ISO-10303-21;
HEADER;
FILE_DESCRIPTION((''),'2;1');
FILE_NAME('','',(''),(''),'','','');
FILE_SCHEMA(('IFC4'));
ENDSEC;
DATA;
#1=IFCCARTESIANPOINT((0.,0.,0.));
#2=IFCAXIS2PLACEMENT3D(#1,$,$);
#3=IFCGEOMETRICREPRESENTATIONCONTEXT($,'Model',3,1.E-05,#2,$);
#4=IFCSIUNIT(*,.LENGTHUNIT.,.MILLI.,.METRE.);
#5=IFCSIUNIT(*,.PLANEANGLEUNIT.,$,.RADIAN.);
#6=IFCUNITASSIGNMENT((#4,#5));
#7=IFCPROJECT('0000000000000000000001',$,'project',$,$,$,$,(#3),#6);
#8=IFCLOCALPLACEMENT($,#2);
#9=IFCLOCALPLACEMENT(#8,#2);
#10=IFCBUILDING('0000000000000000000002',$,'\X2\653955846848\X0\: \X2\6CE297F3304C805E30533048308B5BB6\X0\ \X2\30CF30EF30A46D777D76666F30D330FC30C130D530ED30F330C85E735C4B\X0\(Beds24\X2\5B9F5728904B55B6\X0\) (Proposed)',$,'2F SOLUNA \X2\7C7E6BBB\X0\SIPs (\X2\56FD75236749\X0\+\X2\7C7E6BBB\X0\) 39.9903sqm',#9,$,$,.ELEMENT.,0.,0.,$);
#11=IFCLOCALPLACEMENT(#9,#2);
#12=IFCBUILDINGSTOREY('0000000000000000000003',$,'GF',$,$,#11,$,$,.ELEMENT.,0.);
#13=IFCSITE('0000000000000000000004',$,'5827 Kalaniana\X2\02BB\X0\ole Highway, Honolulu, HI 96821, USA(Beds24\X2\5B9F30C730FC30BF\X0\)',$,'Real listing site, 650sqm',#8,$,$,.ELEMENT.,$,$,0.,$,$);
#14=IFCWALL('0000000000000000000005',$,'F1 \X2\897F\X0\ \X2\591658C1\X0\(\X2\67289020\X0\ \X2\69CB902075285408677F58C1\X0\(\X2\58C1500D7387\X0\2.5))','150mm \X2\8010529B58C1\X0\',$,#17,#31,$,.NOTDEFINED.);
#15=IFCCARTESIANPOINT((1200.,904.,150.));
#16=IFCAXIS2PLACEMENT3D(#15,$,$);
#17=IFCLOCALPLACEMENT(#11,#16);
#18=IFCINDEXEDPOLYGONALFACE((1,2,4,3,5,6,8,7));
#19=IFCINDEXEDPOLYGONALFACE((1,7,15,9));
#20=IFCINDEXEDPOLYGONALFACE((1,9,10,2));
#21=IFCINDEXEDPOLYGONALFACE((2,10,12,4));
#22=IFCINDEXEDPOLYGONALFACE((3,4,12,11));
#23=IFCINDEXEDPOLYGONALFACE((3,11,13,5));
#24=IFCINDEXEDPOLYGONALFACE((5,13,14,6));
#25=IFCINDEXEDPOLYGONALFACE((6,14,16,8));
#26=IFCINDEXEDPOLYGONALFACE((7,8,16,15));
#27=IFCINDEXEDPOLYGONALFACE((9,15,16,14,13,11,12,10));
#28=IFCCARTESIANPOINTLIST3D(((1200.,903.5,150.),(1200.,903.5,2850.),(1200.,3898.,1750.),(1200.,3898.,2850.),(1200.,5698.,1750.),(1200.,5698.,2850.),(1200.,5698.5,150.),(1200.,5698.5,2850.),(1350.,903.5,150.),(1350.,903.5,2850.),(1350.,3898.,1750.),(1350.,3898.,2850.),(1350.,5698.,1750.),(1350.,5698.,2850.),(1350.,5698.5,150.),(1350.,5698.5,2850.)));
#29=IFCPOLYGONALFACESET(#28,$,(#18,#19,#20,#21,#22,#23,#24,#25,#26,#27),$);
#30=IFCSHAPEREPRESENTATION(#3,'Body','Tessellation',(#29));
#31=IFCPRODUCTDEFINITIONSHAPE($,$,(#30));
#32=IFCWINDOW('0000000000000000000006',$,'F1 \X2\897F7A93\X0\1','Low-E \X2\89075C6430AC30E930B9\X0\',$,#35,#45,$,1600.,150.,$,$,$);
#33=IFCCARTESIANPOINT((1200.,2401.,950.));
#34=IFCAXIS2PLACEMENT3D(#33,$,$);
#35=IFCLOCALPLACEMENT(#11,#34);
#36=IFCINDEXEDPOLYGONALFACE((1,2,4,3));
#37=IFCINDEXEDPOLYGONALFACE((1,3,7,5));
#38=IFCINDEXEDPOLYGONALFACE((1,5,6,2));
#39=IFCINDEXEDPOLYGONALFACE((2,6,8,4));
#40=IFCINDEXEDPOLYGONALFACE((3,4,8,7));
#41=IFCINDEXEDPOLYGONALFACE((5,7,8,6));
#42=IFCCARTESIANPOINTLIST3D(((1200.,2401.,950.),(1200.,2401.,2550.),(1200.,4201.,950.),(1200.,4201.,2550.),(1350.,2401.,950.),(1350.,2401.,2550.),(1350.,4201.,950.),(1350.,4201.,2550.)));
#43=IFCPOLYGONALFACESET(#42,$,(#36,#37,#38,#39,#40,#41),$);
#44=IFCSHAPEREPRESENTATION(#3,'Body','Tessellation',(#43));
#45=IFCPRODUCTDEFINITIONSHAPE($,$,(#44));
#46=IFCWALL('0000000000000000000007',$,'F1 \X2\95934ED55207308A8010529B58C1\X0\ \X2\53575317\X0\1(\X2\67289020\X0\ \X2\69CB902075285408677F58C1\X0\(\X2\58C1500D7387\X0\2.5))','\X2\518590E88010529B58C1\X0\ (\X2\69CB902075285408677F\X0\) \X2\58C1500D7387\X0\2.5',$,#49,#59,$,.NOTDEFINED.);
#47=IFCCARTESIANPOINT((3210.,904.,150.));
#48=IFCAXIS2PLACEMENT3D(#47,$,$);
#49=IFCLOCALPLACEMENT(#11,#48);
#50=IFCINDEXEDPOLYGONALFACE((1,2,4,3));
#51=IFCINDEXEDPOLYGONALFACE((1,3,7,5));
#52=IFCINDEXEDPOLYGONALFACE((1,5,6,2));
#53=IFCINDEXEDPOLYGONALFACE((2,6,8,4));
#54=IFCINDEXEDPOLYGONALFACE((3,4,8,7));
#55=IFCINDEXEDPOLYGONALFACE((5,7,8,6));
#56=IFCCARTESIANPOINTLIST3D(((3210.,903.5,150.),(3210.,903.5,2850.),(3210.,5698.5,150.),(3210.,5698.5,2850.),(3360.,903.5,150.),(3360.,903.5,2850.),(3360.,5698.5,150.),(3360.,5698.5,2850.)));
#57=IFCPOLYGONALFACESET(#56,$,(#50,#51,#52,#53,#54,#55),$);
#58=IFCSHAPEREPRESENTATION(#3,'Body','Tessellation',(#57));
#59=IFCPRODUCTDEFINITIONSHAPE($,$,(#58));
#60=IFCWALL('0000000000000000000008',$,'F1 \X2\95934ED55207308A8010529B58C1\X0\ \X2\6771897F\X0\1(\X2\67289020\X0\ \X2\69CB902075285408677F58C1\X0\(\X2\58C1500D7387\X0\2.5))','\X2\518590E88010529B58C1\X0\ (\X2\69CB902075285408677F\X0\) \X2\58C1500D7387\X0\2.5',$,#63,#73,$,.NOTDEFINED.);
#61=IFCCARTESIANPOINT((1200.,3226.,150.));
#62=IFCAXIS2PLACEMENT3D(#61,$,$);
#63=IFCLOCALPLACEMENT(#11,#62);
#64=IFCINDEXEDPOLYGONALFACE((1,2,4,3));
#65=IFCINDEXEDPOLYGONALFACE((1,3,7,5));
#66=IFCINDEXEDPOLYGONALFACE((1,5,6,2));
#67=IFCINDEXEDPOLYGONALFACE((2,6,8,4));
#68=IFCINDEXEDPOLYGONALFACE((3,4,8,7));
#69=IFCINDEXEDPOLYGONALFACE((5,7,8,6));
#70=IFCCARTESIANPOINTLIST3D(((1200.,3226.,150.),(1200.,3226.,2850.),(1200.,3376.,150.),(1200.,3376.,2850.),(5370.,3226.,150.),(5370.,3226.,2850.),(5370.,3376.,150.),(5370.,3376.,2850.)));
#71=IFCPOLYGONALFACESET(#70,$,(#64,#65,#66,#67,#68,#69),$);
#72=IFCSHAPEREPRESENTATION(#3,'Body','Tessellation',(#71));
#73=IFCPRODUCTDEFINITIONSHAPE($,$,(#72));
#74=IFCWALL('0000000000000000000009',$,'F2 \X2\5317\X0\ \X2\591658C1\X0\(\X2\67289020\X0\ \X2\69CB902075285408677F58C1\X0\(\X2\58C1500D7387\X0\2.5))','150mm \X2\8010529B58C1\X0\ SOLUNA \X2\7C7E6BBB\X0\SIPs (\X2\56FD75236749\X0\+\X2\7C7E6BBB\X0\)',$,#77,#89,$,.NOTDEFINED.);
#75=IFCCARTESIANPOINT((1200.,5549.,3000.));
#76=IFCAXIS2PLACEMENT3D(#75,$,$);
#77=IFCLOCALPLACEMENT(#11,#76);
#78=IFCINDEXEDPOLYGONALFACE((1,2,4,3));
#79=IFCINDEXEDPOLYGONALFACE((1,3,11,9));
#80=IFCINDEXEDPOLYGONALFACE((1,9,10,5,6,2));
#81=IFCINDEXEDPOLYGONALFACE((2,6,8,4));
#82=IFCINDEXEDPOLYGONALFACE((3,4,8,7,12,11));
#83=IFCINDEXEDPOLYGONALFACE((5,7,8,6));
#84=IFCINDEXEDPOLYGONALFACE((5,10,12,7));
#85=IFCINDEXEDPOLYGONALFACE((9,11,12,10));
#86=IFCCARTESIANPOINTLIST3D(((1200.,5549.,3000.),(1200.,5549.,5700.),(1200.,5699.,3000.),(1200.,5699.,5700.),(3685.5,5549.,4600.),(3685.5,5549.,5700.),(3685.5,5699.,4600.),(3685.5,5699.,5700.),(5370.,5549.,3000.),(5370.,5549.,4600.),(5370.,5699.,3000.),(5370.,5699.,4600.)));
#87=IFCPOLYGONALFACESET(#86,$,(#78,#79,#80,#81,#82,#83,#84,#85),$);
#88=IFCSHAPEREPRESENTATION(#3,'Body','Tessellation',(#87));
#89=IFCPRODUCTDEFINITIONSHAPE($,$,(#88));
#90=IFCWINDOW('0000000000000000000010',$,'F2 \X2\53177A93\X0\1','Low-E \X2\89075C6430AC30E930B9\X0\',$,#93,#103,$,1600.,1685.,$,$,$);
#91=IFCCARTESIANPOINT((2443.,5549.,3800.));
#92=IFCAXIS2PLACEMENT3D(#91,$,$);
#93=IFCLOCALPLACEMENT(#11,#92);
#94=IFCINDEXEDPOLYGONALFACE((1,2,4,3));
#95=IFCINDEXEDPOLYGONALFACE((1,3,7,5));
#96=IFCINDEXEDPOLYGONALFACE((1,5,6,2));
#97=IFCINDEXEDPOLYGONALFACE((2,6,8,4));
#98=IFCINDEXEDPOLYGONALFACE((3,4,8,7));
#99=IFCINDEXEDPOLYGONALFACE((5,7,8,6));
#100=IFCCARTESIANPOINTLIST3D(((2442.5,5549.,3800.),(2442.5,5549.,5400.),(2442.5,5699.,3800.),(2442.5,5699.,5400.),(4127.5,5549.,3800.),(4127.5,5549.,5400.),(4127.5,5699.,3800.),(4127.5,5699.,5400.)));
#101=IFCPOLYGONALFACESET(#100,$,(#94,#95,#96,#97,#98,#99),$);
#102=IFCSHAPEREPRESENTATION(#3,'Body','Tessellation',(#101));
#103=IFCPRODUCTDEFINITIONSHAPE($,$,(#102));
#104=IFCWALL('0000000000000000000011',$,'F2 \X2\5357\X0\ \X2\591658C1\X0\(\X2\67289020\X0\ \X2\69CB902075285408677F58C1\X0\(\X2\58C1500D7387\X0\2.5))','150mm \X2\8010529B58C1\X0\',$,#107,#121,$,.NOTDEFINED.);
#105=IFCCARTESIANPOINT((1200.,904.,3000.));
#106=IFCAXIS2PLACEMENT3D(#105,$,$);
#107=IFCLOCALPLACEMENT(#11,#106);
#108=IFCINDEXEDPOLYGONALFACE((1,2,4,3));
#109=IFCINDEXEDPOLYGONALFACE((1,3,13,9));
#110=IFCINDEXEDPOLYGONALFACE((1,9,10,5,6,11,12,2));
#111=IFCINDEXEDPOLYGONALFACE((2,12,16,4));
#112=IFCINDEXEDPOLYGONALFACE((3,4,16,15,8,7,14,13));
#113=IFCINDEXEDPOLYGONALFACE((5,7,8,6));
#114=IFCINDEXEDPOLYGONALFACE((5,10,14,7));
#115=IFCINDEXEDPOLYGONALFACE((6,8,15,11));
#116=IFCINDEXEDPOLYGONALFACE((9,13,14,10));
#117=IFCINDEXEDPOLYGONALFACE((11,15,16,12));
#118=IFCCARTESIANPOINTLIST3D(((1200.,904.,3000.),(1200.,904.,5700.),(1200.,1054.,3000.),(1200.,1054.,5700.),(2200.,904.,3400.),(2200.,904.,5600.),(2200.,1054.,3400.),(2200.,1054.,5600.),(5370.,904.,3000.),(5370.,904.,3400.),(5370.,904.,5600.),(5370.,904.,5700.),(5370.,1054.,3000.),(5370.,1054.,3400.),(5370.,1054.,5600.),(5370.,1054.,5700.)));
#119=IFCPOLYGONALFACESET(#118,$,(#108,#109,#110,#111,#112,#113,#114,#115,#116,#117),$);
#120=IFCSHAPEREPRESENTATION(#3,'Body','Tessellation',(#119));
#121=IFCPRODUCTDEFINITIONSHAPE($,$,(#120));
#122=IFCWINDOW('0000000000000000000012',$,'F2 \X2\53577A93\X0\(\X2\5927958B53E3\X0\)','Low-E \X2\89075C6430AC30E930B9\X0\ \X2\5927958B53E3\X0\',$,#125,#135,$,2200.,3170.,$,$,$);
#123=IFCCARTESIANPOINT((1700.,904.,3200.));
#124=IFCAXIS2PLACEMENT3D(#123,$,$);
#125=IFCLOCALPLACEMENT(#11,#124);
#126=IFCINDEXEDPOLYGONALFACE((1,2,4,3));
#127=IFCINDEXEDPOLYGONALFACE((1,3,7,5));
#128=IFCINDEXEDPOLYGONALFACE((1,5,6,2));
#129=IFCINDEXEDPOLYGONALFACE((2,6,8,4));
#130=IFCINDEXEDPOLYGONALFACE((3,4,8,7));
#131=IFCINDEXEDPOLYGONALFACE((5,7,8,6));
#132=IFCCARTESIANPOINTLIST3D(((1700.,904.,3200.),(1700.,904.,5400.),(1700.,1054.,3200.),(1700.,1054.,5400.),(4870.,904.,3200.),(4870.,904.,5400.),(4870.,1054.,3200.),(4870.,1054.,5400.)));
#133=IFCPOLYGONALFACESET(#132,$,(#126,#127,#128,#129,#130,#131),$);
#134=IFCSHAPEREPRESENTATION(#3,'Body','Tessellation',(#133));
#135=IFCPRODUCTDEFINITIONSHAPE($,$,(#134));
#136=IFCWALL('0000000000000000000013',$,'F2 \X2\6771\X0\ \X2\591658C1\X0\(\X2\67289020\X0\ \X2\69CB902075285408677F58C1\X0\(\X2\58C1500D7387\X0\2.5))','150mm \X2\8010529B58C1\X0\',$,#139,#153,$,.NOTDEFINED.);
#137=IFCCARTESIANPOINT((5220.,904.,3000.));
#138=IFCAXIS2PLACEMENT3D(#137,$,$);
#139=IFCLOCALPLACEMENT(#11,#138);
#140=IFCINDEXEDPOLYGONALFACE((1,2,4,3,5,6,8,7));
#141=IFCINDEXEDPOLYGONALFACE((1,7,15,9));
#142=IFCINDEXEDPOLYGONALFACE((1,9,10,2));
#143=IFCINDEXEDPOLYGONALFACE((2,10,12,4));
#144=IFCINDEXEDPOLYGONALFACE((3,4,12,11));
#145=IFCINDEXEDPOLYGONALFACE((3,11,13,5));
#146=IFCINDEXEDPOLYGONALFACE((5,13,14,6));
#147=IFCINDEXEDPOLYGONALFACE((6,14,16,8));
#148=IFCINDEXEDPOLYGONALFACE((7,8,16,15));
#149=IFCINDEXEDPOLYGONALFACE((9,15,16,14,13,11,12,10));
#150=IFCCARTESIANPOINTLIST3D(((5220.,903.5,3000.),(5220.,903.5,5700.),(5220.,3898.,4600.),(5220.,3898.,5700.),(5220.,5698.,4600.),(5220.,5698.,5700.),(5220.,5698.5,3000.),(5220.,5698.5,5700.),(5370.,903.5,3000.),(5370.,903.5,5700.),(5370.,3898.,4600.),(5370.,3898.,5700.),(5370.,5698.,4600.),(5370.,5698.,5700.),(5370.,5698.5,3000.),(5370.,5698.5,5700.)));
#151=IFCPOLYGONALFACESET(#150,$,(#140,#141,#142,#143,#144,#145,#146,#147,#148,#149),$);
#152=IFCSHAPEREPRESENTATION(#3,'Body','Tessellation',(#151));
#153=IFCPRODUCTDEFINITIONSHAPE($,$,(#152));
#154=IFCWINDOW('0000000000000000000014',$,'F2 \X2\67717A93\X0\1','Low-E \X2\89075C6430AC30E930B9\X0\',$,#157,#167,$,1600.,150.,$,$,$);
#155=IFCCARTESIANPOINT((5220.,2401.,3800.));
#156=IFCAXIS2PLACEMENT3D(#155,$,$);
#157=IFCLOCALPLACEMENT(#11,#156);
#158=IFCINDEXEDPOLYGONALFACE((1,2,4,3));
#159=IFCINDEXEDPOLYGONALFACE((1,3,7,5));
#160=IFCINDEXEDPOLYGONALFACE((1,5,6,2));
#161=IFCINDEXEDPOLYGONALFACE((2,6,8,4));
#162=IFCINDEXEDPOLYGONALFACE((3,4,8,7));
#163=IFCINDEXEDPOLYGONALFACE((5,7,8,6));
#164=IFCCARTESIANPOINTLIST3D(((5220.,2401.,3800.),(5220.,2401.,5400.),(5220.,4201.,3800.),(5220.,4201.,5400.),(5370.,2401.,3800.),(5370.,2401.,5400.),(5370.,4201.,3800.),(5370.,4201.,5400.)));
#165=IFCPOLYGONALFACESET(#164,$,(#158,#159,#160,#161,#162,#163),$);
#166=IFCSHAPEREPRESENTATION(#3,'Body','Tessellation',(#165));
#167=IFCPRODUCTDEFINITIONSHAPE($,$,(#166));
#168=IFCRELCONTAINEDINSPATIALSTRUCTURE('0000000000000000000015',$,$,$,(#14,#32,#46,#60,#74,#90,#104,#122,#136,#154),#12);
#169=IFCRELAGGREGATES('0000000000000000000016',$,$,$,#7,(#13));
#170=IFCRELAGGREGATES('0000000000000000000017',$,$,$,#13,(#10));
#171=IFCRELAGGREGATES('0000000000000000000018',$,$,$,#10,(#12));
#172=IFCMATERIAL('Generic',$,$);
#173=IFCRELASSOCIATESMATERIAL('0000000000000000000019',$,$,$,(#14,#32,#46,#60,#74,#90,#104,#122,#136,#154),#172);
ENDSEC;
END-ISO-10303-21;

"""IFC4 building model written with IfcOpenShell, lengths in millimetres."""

from ifc_helpers import new_model, si_unit, frame, frame_2d, origin, place, context, project, spatial, rectangle, extrude, material, element, fill, save


model = new_model("IFC4")

# Units and contexts
model_context = context("Model", 3, precision=1e-05, world=origin())
ifc_project = project(units=[si_unit("LENGTHUNIT", "METRE", prefix="MILLI"), si_unit("PLANEANGLEUNIT", "RADIAN")], contexts=[model_context])

# Site, building, storey
site_placement = place(None, origin())
site = spatial("IfcSite", under=ifc_project, at=site_placement, Name="5827 Kalanianaʻole Highway, Honolulu, HI 96821, USA(Beds24実データ)", ObjectType="Real listing site, 650sqm", CompositionType="ELEMENT", RefElevation=0.0)
building_placement = place(site_placement, origin())
building = spatial("IfcBuilding", under=site, at=building_placement, Name="改善案: 波音が聞こえる家 ハワイ海絶景ビーチフロント平屋(Beds24実在運営) (Proposed)", ObjectType="2F SOLUNA 籾殻SIPs (国産杉+籾殻) 39.9903sqm", CompositionType="ELEMENT", ElevationOfRefHeight=0.0, ElevationOfTerrain=0.0)
storey_placement = place(building_placement, origin())
storey = spatial("IfcBuildingStorey", under=building, at=storey_placement, Name="GF", CompositionType="ELEMENT", Elevation=0.0)

# Shared definitions
ifc_material_1 = material(Name="Generic")

# Wall, opening, window
wall_1_placement = place(storey_placement, frame((1200.0, 904.0, 150.0)))
wall_1 = element("IfcWall", 1, at=wall_1_placement, inside=storey, material=ifc_material_1, Name="F1 西 外壁(木造 構造用合板壁(壁倍率2.5))", Description="150mm 耐力壁", PredefinedType="NOTDEFINED", context=model_context, shape_type="SweptSolid", body=[
    extrude(rectangle(XDim=150.0, YDim=4795.0, at=frame_2d((75.0, 2397.0))), frame((1200.0, 904.0, 150.0)), (0.0, 0.0, 1.0), 2700.0),
])
opening_1_placement = place(storey_placement, frame((1200.0, 2401.0, 950.0)))
opening_1 = element("IfcOpeningElement", 2, at=opening_1_placement, cuts=wall_1, PredefinedType="NOTDEFINED", context=model_context, shape_type="SweptSolid", body=[
    extrude(rectangle(XDim=150.0, YDim=1800.0, at=frame_2d((75.0, 900.0))), frame((1200.0, 2401.0, 950.0)), (0.0, 0.0, 1.0), 1600.0),
])
window_1_placement = place(storey_placement, frame((1200.0, 2401.0, 950.0)))
window_1 = element("IfcWindow", 3, at=window_1_placement, inside=storey, material=ifc_material_1, Name="F1 西窓1", Description="Low-E 複層ガラス", OverallHeight=1600.0, OverallWidth=150.0, context=model_context, shape_type="SweptSolid", body=[
    extrude(rectangle(XDim=150.0, YDim=1800.0, at=frame_2d((75.0, 900.0))), frame((1200.0, 2401.0, 950.0)), (0.0, 0.0, 1.0), 1600.0),
])
fill(opening_1, window_1)

# Walls
wall_2_placement = place(storey_placement, frame((3210.0, 904.0, 150.0)))
element("IfcWall", 4, at=wall_2_placement, inside=storey, material=ifc_material_1, Name="F1 間仕切り耐力壁 南北1(木造 構造用合板壁(壁倍率2.5))", Description="内部耐力壁 (構造用合板) 壁倍率2.5", PredefinedType="NOTDEFINED", context=model_context, shape_type="SweptSolid", body=[
    extrude(rectangle(XDim=150.0, YDim=4795.0, at=frame_2d((75.0, 2397.0))), frame((3210.0, 904.0, 150.0)), (0.0, 0.0, 1.0), 2700.0),
])
wall_3_placement = place(storey_placement, frame((1200.0, 3226.0, 150.0)))
element("IfcWall", 5, at=wall_3_placement, inside=storey, material=ifc_material_1, Name="F1 間仕切り耐力壁 東西1(木造 構造用合板壁(壁倍率2.5))", Description="内部耐力壁 (構造用合板) 壁倍率2.5", PredefinedType="NOTDEFINED", context=model_context, shape_type="SweptSolid", body=[
    extrude(rectangle(XDim=4170.0, YDim=150.0, at=frame_2d((2085.0, 75.0))), frame((1200.0, 3226.0, 150.0)), (0.0, 0.0, 1.0), 2700.0),
])

# Walls, openings, windows
wall_4_placement = place(storey_placement, frame((1200.0, 5549.0, 3000.0)))
wall_4 = element("IfcWall", 6, at=wall_4_placement, inside=storey, material=ifc_material_1, Name="F2 北 外壁(木造 構造用合板壁(壁倍率2.5))", Description="150mm 耐力壁 SOLUNA 籾殻SIPs (国産杉+籾殻)", PredefinedType="NOTDEFINED", context=model_context, shape_type="SweptSolid", body=[
    extrude(rectangle(XDim=4170.0, YDim=150.0, at=frame_2d((2085.0, 75.0))), frame((1200.0, 5549.0, 3000.0)), (0.0, 0.0, 1.0), 2700.0),
])
opening_2_placement = place(storey_placement, frame((2443.0, 5549.0, 3800.0)))
opening_2 = element("IfcOpeningElement", 7, at=opening_2_placement, cuts=wall_4, PredefinedType="NOTDEFINED", context=model_context, shape_type="SweptSolid", body=[
    extrude(rectangle(XDim=1685.0, YDim=150.0, at=frame_2d((842.0, 75.0))), frame((2443.0, 5549.0, 3800.0)), (0.0, 0.0, 1.0), 1600.0),
])
window_2_placement = place(storey_placement, frame((2443.0, 5549.0, 3800.0)))
window_2 = element("IfcWindow", 8, at=window_2_placement, inside=storey, material=ifc_material_1, Name="F2 北窓1", Description="Low-E 複層ガラス", OverallHeight=1600.0, OverallWidth=1685.0, context=model_context, shape_type="SweptSolid", body=[
    extrude(rectangle(XDim=1685.0, YDim=150.0, at=frame_2d((842.0, 75.0))), frame((2443.0, 5549.0, 3800.0)), (0.0, 0.0, 1.0), 1600.0),
])
fill(opening_2, window_2)
wall_5_placement = place(storey_placement, frame((1200.0, 904.0, 3000.0)))
wall_5 = element("IfcWall", 9, at=wall_5_placement, inside=storey, material=ifc_material_1, Name="F2 南 外壁(木造 構造用合板壁(壁倍率2.5))", Description="150mm 耐力壁", PredefinedType="NOTDEFINED", context=model_context, shape_type="SweptSolid", body=[
    extrude(rectangle(XDim=4170.0, YDim=150.0, at=frame_2d((2085.0, 75.0))), frame((1200.0, 904.0, 3000.0)), (0.0, 0.0, 1.0), 2700.0),
])
opening_3_placement = place(storey_placement, frame((1700.0, 904.0, 3200.0)))
opening_3 = element("IfcOpeningElement", 10, at=opening_3_placement, cuts=wall_5, PredefinedType="NOTDEFINED", context=model_context, shape_type="SweptSolid", body=[
    extrude(rectangle(XDim=3170.0, YDim=150.0, at=frame_2d((1585.0, 75.0))), frame((1700.0, 904.0, 3200.0)), (0.0, 0.0, 1.0), 2200.0),
])
window_3_placement = place(storey_placement, frame((1700.0, 904.0, 3200.0)))
window_3 = element("IfcWindow", 11, at=window_3_placement, inside=storey, material=ifc_material_1, Name="F2 南窓(大開口)", Description="Low-E 複層ガラス 大開口", OverallHeight=2200.0, OverallWidth=3170.0, context=model_context, shape_type="SweptSolid", body=[
    extrude(rectangle(XDim=3170.0, YDim=150.0, at=frame_2d((1585.0, 75.0))), frame((1700.0, 904.0, 3200.0)), (0.0, 0.0, 1.0), 2200.0),
])
fill(opening_3, window_3)
wall_6_placement = place(storey_placement, frame((5220.0, 904.0, 3000.0)))
wall_6 = element("IfcWall", 12, at=wall_6_placement, inside=storey, material=ifc_material_1, Name="F2 東 外壁(木造 構造用合板壁(壁倍率2.5))", Description="150mm 耐力壁", PredefinedType="NOTDEFINED", context=model_context, shape_type="SweptSolid", body=[
    extrude(rectangle(XDim=150.0, YDim=4795.0, at=frame_2d((75.0, 2397.0))), frame((5220.0, 904.0, 3000.0)), (0.0, 0.0, 1.0), 2700.0),
])
opening_4_placement = place(storey_placement, frame((5220.0, 2401.0, 3800.0)))
opening_4 = element("IfcOpeningElement", 13, at=opening_4_placement, cuts=wall_6, PredefinedType="NOTDEFINED", context=model_context, shape_type="SweptSolid", body=[
    extrude(rectangle(XDim=150.0, YDim=1800.0, at=frame_2d((75.0, 900.0))), frame((5220.0, 2401.0, 3800.0)), (0.0, 0.0, 1.0), 1600.0),
])
window_4_placement = place(storey_placement, frame((5220.0, 2401.0, 3800.0)))
window_4 = element("IfcWindow", 14, at=window_4_placement, inside=storey, material=ifc_material_1, Name="F2 東窓1", Description="Low-E 複層ガラス", OverallHeight=1600.0, OverallWidth=150.0, context=model_context, shape_type="SweptSolid", body=[
    extrude(rectangle(XDim=150.0, YDim=1800.0, at=frame_2d((75.0, 900.0))), frame((5220.0, 2401.0, 3800.0)), (0.0, 0.0, 1.0), 1600.0),
])
fill(opening_4, window_4)

save(model, "model.ifc")
